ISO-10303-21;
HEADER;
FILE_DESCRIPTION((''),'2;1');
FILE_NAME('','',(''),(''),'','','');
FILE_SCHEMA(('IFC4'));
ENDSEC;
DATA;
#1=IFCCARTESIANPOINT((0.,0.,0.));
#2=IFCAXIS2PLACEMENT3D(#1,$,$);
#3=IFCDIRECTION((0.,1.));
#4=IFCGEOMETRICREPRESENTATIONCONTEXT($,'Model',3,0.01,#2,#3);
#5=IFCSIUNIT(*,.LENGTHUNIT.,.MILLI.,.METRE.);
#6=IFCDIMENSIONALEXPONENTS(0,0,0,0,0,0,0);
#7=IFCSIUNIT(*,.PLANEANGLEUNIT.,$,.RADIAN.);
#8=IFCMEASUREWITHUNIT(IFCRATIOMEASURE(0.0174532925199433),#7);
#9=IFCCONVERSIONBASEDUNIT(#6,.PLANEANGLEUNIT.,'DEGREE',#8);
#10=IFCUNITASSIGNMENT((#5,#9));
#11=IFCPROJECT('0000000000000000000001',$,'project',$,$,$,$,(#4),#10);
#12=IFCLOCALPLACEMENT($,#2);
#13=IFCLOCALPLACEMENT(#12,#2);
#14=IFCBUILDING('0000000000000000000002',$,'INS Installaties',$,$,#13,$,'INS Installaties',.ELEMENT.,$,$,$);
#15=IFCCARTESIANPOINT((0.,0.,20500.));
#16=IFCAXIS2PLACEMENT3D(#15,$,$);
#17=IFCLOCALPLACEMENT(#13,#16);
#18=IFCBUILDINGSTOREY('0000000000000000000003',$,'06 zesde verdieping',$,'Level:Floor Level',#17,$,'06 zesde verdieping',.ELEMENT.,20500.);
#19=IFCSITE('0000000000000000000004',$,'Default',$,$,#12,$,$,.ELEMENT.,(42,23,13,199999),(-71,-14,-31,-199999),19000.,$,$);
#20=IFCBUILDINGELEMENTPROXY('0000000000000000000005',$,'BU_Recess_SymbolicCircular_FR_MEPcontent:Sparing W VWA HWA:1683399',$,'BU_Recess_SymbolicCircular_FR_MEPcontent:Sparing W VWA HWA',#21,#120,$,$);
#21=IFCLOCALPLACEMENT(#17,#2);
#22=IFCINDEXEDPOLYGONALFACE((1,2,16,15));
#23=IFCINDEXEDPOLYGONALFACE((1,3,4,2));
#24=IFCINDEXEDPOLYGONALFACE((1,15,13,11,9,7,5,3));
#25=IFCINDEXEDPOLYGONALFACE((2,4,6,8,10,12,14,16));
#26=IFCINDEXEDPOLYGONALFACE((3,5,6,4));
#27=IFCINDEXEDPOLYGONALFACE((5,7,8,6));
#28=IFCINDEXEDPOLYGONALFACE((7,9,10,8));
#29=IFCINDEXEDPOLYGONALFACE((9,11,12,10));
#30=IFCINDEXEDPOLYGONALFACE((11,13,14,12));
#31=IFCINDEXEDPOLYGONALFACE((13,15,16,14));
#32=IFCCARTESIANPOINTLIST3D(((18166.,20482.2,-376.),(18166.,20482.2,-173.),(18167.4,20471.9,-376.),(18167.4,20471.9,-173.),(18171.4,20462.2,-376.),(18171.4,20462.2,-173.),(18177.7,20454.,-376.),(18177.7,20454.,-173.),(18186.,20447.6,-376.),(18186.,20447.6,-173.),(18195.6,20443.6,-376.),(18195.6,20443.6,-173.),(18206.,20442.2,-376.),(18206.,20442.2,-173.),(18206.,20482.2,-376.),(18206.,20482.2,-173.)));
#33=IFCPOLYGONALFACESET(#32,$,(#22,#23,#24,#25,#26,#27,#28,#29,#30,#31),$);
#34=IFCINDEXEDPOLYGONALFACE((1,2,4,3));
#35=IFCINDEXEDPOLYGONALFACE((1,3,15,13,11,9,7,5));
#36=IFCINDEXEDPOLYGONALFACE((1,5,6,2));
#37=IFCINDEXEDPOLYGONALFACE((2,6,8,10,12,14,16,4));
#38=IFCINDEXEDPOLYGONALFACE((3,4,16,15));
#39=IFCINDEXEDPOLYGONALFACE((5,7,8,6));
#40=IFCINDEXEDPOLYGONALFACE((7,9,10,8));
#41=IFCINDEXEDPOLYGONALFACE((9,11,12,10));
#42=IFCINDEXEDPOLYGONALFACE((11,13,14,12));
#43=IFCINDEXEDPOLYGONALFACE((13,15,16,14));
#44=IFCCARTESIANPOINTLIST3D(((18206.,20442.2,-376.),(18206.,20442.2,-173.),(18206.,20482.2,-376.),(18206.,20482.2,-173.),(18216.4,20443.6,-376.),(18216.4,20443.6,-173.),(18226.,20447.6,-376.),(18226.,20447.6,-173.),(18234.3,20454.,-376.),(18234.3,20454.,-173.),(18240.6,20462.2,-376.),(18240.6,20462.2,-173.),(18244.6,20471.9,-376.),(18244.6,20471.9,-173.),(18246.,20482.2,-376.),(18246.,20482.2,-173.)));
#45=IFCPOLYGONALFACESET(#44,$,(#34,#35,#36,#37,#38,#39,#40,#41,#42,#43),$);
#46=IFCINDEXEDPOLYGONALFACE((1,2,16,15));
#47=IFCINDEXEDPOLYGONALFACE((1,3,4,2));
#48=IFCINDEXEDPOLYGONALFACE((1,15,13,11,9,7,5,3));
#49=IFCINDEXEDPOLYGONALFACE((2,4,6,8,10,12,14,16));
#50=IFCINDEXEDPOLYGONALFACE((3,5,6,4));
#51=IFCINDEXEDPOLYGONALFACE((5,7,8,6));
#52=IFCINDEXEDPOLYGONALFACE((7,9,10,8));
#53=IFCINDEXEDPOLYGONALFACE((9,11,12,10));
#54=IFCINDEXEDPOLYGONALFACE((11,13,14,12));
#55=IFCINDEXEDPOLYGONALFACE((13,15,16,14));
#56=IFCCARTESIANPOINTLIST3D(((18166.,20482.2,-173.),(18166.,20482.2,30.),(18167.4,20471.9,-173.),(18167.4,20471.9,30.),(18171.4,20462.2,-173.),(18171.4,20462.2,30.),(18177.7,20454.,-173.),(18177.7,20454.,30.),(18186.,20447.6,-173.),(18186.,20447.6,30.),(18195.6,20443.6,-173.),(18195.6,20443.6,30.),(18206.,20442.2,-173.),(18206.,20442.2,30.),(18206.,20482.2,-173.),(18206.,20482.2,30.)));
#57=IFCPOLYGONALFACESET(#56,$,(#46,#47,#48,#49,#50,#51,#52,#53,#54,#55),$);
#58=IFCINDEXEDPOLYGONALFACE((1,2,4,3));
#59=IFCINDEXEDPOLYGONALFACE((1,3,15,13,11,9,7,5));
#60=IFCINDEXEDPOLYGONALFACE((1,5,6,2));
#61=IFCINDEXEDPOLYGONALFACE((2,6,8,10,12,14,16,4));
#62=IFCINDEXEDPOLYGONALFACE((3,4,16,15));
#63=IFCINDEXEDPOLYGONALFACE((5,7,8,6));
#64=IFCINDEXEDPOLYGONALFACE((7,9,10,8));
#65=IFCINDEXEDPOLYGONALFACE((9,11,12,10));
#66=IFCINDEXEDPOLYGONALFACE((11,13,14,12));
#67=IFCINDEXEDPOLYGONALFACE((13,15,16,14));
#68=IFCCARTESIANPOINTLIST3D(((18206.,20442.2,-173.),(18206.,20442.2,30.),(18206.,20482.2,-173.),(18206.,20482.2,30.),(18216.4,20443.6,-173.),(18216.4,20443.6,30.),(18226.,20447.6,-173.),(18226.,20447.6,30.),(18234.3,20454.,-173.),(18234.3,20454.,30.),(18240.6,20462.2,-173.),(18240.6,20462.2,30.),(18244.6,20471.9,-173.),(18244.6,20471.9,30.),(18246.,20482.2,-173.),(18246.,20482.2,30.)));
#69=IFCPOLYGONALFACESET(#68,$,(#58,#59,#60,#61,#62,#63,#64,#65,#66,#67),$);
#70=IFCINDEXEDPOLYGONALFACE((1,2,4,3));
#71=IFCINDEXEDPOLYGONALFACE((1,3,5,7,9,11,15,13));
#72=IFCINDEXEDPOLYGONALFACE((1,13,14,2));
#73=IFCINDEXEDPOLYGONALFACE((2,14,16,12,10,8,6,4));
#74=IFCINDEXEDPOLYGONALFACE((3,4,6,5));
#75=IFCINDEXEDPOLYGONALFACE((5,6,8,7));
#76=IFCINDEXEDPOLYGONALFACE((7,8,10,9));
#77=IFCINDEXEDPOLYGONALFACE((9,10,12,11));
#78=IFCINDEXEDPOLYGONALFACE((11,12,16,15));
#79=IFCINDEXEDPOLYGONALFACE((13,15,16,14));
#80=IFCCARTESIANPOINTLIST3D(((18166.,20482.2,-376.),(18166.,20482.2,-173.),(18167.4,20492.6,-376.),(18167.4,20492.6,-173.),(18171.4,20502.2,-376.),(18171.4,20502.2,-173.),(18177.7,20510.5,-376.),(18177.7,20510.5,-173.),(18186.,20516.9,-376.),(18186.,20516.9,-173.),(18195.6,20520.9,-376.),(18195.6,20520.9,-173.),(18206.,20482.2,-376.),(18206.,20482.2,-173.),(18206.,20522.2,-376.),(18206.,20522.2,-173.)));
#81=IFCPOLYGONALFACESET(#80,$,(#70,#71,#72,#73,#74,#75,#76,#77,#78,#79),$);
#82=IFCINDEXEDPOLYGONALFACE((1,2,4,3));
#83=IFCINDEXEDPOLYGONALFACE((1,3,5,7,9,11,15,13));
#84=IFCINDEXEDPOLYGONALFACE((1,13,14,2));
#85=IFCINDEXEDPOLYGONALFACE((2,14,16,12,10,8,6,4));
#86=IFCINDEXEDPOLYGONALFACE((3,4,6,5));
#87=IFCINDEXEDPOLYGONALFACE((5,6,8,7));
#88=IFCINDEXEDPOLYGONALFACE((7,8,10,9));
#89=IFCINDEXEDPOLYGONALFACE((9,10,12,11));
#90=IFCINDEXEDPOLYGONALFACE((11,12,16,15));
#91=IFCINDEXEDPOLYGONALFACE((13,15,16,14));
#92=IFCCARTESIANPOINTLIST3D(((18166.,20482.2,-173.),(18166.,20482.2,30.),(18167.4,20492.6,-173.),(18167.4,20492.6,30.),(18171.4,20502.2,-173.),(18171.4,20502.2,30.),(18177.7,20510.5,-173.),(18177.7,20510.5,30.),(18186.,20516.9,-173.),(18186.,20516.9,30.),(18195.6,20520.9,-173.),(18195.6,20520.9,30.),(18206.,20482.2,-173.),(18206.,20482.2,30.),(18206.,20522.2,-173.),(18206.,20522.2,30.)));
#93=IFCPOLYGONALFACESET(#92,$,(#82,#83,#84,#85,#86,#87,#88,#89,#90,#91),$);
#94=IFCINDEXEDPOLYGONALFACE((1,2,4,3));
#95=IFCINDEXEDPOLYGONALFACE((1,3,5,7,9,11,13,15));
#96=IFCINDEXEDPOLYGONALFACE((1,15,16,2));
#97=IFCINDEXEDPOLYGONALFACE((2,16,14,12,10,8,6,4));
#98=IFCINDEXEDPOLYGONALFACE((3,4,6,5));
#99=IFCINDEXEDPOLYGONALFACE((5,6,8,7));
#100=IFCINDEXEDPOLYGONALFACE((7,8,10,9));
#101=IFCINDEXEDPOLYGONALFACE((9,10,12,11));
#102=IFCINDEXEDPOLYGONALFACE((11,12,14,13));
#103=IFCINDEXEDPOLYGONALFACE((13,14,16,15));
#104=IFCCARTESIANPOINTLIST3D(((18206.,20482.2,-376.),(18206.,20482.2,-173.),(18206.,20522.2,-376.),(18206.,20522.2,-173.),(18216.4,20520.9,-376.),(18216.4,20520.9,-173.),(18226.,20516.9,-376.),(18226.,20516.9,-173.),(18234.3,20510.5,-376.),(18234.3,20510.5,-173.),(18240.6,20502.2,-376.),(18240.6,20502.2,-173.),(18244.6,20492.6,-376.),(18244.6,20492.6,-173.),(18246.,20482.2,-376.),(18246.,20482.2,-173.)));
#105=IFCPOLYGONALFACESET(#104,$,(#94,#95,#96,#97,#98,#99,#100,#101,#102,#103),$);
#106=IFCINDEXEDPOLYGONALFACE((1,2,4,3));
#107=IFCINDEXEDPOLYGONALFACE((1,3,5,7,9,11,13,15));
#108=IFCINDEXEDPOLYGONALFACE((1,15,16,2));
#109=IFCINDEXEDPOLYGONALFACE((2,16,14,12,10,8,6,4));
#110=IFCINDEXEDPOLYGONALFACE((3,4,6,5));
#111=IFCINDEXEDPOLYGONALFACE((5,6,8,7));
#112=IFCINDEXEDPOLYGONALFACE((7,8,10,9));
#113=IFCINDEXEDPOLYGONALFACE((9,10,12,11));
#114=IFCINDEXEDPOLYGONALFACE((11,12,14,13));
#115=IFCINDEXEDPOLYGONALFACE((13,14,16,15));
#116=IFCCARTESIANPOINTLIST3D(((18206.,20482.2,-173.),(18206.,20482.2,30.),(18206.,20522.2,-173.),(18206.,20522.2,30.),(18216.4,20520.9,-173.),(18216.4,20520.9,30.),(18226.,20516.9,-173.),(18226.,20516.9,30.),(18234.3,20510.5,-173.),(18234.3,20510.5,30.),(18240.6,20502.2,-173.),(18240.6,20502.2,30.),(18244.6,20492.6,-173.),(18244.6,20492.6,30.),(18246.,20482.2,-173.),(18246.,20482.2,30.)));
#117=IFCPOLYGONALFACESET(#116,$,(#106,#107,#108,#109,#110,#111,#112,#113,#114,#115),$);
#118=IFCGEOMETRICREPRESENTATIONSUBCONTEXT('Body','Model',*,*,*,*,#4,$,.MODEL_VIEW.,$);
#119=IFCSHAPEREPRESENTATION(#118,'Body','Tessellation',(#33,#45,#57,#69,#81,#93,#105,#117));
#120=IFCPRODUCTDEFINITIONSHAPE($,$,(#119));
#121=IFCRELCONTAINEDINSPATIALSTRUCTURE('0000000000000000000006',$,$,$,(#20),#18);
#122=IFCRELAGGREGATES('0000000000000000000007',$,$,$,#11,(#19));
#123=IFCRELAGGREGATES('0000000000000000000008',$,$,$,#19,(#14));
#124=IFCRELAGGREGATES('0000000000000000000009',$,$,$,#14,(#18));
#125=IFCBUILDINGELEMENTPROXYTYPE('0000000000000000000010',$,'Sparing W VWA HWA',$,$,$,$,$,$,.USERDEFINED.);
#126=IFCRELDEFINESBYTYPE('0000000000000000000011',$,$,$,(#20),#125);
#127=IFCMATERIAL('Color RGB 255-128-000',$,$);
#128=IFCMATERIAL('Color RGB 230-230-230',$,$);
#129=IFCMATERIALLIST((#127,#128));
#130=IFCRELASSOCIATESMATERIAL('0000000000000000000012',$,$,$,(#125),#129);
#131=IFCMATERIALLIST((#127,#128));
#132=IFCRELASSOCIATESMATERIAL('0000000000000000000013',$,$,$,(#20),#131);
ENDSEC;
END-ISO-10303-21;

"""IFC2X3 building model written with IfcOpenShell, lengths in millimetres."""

from ifc_helpers import new_model, entity, si_unit, converted_unit, direction, frame, frame_2d, origin, place, context, subcontext, project, spatial, polyline, circle_curve, parameter, trimmed, segment, composite_curve, outline, extrude, source, transform, mapped, material, material_list, type_object, type_shapes, element, save


model = new_model("IFC2X3")

# Units and contexts
model_context = context("Model", 3, precision=0.01, world=origin(), true_north=direction((0.0, 1.0)))
body_context = subcontext(model_context, "Body", "Model", "MODEL_VIEW")
ifc_project = project(units=[si_unit("LENGTHUNIT", "METRE", prefix="MILLI"), converted_unit("PLANEANGLEUNIT", "DEGREE", entity("IfcRatioMeasure", 0.0174532925199433), si_unit("PLANEANGLEUNIT", "RADIAN"), dimensions=[0, 0, 0, 0, 0, 0, 0])], contexts=[model_context])

# Site, building, storey
site_placement = place(None, origin())
site = spatial("IfcSite", under=ifc_project, at=site_placement, Name="Default", CompositionType="ELEMENT", RefLatitude=(42, 23, 13, 199999), RefLongitude=(-71, -14, -31, -199999), RefElevation=19000.0)
building_placement = place(site_placement, origin())
building = spatial("IfcBuilding", under=site, at=building_placement, Name="INS Installaties", LongName="INS Installaties", CompositionType="ELEMENT")
storey_placement = place(building_placement, frame((0.0, 0.0, 20500.0)))
storey = spatial("IfcBuildingStorey", under=building, at=storey_placement, Name="06 zesde verdieping", ObjectType="Level:Floor Level", LongName="06 zesde verdieping", CompositionType="ELEMENT", Elevation=20500.0)

# Building element proxy
ifc_material_1 = material(Name="Color RGB 255-128-000")
ifc_material_2 = material(Name="Color RGB 230-230-230")
ifc_material_list_1 = material_list([ifc_material_1, ifc_material_2])
building_element_proxy_type_1 = type_object("IfcBuildingElementProxyType", Name="Sparing W VWA HWA", PredefinedType="USERDEFINED", material=ifc_material_list_1)
shared_shape_1 = source(origin(), body_context, "Body", "SweptSolid", [
    extrude(outline(composite_curve([segment(trimmed(circle_curve(frame_2d((13.3, 13.3), x_axis=(1.0, 0.0)), 40.0), [parameter(180.0)], [parameter(270.0)], True, "PARAMETER"), True, "CONTINUOUS"), segment(polyline([(13.3, -26.7), (13.3, 13.3)]), True, "CONTINUOUS"), segment(polyline([(13.3, 13.3), (-26.7, 13.3)]), True, "CONTINUOUS")], self_intersect=False)), frame((13.3, 13.3, -403.0), z_axis=(0.0, 0.0, 1.0), x_axis=(-1.0, 0.0, 0.0)), (0.0, 0.0, 1.0), 203.0),
    extrude(outline(composite_curve([segment(polyline([(-26.7, -13.3), (13.3, -13.3)]), True, "CONTINUOUS"), segment(polyline([(13.3, -13.3), (13.3, 26.7)]), True, "CONTINUOUS"), segment(trimmed(circle_curve(frame_2d((13.3, -13.3), x_axis=(1.0, 0.0)), 40.0), [parameter(90.0)], [parameter(180.0)], True, "PARAMETER"), True, "CONTINUOUS")], self_intersect=False)), frame((-13.3, 13.3, -403.0)), (0.0, 0.0, 1.0), 203.0),
    extrude(outline(composite_curve([segment(trimmed(circle_curve(frame_2d((13.3, 13.3), x_axis=(1.0, 0.0)), 40.0), [parameter(180.0)], [parameter(270.0)], True, "PARAMETER"), True, "CONTINUOUS"), segment(polyline([(13.3, -26.7), (13.3, 13.3)]), True, "CONTINUOUS"), segment(polyline([(13.3, 13.3), (-26.7, 13.3)]), True, "CONTINUOUS")], self_intersect=False)), frame((13.3, 13.3, -200.0), z_axis=(0.0, 0.0, 1.0), x_axis=(-1.0, 0.0, 0.0)), (0.0, 0.0, 1.0), 203.0),
    extrude(outline(composite_curve([segment(polyline([(-26.7, -13.3), (13.3, -13.3)]), True, "CONTINUOUS"), segment(polyline([(13.3, -13.3), (13.3, 26.7)]), True, "CONTINUOUS"), segment(trimmed(circle_curve(frame_2d((13.3, -13.3), x_axis=(1.0, 0.0)), 40.0), [parameter(90.0)], [parameter(180.0)], True, "PARAMETER"), True, "CONTINUOUS")], self_intersect=False)), frame((-13.3, 13.3, -200.0)), (0.0, 0.0, 1.0), 203.0),
    extrude(outline(composite_curve([segment(polyline([(-26.7, -13.3), (13.3, -13.3)]), True, "CONTINUOUS"), segment(polyline([(13.3, -13.3), (13.3, 26.7)]), True, "CONTINUOUS"), segment(trimmed(circle_curve(frame_2d((13.3, -13.3), x_axis=(1.0, 0.0)), 40.0), [parameter(90.0)], [parameter(180.0)], True, "PARAMETER"), True, "CONTINUOUS")], self_intersect=False)), frame((13.3, -13.3, -403.0), z_axis=(0.0, 0.0, 1.0), x_axis=(-1.0, 0.0, 0.0)), (0.0, 0.0, 1.0), 203.0),
    extrude(outline(composite_curve([segment(polyline([(-26.7, -13.3), (13.3, -13.3)]), True, "CONTINUOUS"), segment(polyline([(13.3, -13.3), (13.3, 26.7)]), True, "CONTINUOUS"), segment(trimmed(circle_curve(frame_2d((13.3, -13.3), x_axis=(1.0, 0.0)), 40.0), [parameter(90.0)], [parameter(180.0)], True, "PARAMETER"), True, "CONTINUOUS")], self_intersect=False)), frame((13.3, -13.3, -200.0), z_axis=(0.0, 0.0, 1.0), x_axis=(-1.0, 0.0, 0.0)), (0.0, 0.0, 1.0), 203.0),
    extrude(outline(composite_curve([segment(trimmed(circle_curve(frame_2d((13.3, 13.3), x_axis=(1.0, 0.0)), 40.0), [parameter(180.0)], [parameter(270.0)], True, "PARAMETER"), True, "CONTINUOUS"), segment(polyline([(13.3, -26.7), (13.3, 13.3)]), True, "CONTINUOUS"), segment(polyline([(13.3, 13.3), (-26.7, 13.3)]), True, "CONTINUOUS")], self_intersect=False)), frame((-13.3, -13.3, -403.0)), (0.0, 0.0, 1.0), 203.0),
    extrude(outline(composite_curve([segment(trimmed(circle_curve(frame_2d((13.3, 13.3), x_axis=(1.0, 0.0)), 40.0), [parameter(180.0)], [parameter(270.0)], True, "PARAMETER"), True, "CONTINUOUS"), segment(polyline([(13.3, -26.7), (13.3, 13.3)]), True, "CONTINUOUS"), segment(polyline([(13.3, 13.3), (-26.7, 13.3)]), True, "CONTINUOUS")], self_intersect=False)), frame((-13.3, -13.3, -200.0)), (0.0, 0.0, 1.0), 203.0),
])
type_shapes(building_element_proxy_type_1, [shared_shape_1])
ifc_material_list_2 = material_list([ifc_material_1, ifc_material_2])
proxy_1_placement = place(storey_placement, frame((18206.0, 20482.2, 27.0), z_axis=(0.0, 0.0, 1.0), x_axis=(-1.0, 0.0, 0.0)))
element("IfcBuildingElementProxy", 1, at=proxy_1_placement, inside=storey, type_object=building_element_proxy_type_1, material=ifc_material_list_2, Name="BU_Recess_SymbolicCircular_FR_MEPcontent:Sparing W VWA HWA:1683399", ObjectType="BU_Recess_SymbolicCircular_FR_MEPcontent:Sparing W VWA HWA", context=body_context, shape_type="MappedRepresentation", body=[
    mapped(shared_shape_1, transform((0.0, 0.0, 0.0), scale=1.0)),
])

save(model, "model.ifc")
